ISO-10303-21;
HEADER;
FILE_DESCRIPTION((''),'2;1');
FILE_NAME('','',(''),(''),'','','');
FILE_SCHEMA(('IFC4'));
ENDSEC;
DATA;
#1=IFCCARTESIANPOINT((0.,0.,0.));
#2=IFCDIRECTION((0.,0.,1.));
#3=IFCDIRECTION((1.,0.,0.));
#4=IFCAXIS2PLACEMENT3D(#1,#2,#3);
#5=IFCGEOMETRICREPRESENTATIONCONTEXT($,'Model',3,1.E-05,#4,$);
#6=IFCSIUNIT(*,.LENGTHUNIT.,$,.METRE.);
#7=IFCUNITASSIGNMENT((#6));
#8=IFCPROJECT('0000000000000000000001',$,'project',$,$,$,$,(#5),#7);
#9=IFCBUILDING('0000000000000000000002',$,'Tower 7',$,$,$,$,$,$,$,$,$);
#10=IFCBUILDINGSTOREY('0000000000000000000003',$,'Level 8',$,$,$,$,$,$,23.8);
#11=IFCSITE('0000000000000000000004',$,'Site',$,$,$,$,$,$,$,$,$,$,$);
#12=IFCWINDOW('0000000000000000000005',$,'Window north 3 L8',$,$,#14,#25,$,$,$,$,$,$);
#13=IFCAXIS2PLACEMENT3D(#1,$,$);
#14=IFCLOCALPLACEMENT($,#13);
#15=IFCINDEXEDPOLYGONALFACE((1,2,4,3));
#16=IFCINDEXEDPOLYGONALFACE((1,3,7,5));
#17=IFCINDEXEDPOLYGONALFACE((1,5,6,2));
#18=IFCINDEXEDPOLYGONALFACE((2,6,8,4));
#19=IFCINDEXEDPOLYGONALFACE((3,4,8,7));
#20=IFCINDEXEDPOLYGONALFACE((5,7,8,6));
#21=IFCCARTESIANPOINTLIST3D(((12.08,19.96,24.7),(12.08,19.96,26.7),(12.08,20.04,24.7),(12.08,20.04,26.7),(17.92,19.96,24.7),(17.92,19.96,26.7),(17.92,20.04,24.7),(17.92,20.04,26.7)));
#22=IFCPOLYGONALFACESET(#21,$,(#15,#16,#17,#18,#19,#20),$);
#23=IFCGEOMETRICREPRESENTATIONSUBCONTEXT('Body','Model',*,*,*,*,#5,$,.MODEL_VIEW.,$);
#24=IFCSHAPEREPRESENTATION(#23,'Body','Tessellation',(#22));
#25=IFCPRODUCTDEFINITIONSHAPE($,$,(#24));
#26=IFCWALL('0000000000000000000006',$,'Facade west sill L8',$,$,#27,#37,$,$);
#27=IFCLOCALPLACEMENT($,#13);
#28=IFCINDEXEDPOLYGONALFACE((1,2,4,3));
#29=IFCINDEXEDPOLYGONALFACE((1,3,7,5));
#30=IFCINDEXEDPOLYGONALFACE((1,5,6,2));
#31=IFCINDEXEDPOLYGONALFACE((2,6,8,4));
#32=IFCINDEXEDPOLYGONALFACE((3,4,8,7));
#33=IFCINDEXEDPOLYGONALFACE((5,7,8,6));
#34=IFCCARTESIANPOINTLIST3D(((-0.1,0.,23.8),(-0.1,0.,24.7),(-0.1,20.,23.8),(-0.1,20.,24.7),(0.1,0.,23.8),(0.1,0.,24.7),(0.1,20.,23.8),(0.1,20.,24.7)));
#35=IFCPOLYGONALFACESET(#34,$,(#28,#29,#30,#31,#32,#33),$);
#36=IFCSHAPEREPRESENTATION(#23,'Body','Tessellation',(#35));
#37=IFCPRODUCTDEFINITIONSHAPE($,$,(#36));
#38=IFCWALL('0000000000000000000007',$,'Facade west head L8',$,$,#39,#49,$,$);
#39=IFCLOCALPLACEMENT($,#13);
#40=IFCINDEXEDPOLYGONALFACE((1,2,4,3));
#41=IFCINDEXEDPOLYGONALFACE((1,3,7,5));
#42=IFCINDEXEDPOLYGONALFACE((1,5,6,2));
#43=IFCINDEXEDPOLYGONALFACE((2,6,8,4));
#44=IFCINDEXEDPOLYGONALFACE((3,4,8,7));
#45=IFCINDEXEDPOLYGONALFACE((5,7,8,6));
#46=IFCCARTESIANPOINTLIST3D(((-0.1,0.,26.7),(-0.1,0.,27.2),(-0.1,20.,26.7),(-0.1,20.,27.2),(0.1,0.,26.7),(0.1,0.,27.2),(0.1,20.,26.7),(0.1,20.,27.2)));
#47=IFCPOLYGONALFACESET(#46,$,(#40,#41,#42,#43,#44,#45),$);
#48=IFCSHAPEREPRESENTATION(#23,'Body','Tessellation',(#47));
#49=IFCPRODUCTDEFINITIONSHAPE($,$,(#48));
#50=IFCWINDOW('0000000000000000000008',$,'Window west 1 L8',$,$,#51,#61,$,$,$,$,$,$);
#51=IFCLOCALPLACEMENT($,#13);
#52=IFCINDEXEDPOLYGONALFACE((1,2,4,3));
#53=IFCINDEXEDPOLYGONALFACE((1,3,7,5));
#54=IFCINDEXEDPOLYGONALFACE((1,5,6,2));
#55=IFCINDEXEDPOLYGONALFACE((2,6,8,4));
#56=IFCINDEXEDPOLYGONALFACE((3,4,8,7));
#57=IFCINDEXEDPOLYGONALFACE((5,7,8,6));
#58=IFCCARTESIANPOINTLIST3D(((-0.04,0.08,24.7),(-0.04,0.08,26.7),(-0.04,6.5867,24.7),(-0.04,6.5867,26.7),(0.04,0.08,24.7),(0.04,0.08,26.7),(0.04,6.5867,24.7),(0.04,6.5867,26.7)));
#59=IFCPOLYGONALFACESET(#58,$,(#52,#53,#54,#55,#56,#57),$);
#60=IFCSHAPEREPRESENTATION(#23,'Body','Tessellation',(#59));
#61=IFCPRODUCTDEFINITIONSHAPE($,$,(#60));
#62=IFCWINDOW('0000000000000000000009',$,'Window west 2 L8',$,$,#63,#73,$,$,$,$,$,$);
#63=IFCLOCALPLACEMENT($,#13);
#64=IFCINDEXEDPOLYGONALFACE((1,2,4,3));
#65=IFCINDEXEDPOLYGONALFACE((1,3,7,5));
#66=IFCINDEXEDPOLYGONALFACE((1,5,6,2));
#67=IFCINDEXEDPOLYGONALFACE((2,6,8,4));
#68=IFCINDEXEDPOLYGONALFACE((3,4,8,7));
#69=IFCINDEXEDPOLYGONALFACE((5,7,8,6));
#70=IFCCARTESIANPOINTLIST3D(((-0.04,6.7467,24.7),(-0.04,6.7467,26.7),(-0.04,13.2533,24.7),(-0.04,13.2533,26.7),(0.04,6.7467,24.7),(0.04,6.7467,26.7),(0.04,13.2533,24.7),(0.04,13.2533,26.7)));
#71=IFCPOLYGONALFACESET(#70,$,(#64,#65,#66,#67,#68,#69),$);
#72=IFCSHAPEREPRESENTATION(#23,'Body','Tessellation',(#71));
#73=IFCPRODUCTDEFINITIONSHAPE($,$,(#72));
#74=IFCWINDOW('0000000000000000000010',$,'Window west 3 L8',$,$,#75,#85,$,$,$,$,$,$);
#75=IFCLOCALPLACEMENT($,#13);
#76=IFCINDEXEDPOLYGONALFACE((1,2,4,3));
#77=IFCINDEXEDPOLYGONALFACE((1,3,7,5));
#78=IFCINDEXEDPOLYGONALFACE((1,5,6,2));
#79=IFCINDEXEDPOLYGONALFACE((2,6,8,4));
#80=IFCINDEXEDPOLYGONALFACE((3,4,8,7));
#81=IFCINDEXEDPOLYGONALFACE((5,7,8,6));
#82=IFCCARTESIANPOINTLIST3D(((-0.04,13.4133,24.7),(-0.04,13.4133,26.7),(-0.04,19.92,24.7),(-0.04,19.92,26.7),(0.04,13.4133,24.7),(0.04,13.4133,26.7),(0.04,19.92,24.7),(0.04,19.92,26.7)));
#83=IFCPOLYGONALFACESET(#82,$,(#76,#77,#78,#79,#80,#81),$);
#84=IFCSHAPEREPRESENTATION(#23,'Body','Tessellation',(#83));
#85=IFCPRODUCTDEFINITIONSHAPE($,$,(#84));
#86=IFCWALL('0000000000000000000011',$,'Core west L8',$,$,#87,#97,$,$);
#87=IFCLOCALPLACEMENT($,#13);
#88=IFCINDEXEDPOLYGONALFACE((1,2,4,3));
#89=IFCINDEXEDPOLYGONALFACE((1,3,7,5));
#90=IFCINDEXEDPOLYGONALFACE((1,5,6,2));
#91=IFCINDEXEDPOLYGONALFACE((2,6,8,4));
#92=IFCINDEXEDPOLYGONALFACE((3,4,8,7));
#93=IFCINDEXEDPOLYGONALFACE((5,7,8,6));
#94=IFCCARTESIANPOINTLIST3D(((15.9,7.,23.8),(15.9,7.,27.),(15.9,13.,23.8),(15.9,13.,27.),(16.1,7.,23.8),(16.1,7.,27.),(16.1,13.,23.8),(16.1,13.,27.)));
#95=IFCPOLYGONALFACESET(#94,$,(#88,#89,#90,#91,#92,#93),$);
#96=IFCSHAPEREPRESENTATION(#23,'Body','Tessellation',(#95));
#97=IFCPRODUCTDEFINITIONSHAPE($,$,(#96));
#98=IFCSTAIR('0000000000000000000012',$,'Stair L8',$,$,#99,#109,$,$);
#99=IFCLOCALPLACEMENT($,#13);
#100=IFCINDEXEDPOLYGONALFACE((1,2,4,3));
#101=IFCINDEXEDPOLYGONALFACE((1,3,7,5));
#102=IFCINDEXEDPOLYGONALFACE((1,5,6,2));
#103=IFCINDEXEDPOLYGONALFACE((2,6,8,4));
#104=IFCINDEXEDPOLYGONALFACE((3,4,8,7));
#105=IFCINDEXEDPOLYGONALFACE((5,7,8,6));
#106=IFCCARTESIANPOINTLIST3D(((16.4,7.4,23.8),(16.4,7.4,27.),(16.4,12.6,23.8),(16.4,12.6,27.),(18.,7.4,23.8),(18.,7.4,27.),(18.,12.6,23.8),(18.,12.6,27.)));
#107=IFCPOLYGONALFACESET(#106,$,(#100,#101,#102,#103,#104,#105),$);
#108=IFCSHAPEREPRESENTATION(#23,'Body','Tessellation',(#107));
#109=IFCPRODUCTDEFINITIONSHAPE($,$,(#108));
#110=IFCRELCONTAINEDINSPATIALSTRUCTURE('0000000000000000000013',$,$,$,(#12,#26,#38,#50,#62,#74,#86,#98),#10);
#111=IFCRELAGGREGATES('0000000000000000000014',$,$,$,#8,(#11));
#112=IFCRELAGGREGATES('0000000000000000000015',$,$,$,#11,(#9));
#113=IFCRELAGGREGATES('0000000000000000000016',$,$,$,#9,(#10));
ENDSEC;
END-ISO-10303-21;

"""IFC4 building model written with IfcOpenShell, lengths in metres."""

from ifc_helpers import new_model, si_unit, frame, origin, origin_with_axes, origin_2d, place, context, subcontext, project, spatial, rectangle, extrude, element, save


model = new_model("IFC4")

# Units and contexts
model_context = context("Model", 3, precision=1e-05, world=origin_with_axes())
body_context = subcontext(model_context, "Body", "Model", "MODEL_VIEW")
ifc_project = project(units=[si_unit("LENGTHUNIT", "METRE")], contexts=[model_context])

# Site, building, storey
site = spatial("IfcSite", under=ifc_project, Name="Site")
building = spatial("IfcBuilding", under=site, Name="Tower 7")
storey = spatial("IfcBuildingStorey", under=building, Name="Level 8", Elevation=23.8)

# Window
window_1_placement = place(None, frame((15.0, 20.0, 24.7), z_axis=(0.0, 0.0, 1.0), x_axis=(1.0, 0.0, 0.0)))
element("IfcWindow", 1, at=window_1_placement, inside=storey, Name="Window north 3 L8", context=body_context, shape_type="SweptSolid", body=[
    extrude(rectangle(XDim=5.84, YDim=0.08, at=origin_2d()), origin(), (0.0, 0.0, 1.0), 2.0),
])

# Walls
wall_1_placement = place(None, frame((0.0, 10.0, 23.8), z_axis=(0.0, 0.0, 1.0), x_axis=(1.0, 0.0, 0.0)))
element("IfcWall", 2, at=wall_1_placement, inside=storey, Name="Facade west sill L8", context=body_context, shape_type="SweptSolid", body=[
    extrude(rectangle(XDim=0.2, YDim=20.0, at=origin_2d()), origin(), (0.0, 0.0, 1.0), 0.9),
])
wall_2_placement = place(None, frame((0.0, 10.0, 26.7), z_axis=(0.0, 0.0, 1.0), x_axis=(1.0, 0.0, 0.0)))
element("IfcWall", 3, at=wall_2_placement, inside=storey, Name="Facade west head L8", context=body_context, shape_type="SweptSolid", body=[
    extrude(rectangle(XDim=0.2, YDim=20.0, at=origin_2d()), origin(), (0.0, 0.0, 1.0), 0.5),
])

# Windows
for number, where, z_axis, x_axis, name in (
    (4, (0.0, 3.3333, 24.7), (0.0, 0.0, 1.0), (1.0, 0.0, 0.0), "Window west 1 L8"),
    (5, (0.0, 10.0, 24.7), (0.0, 0.0, 1.0), (1.0, 0.0, 0.0), "Window west 2 L8"),
):
    element("IfcWindow", number, at=place(None, frame(where, z_axis=z_axis, x_axis=x_axis)), inside=storey, Name=name, context=body_context, shape_type="SweptSolid", body=[
        extrude(rectangle(XDim=0.08, YDim=6.5067, at=origin_2d()), origin(), (0.0, 0.0, 1.0), 2.0),
    ])
window_2_placement = place(None, frame((0.0, 16.6667, 24.7), z_axis=(0.0, 0.0, 1.0), x_axis=(1.0, 0.0, 0.0)))
element("IfcWindow", 6, at=window_2_placement, inside=storey, Name="Window west 3 L8", context=body_context, shape_type="SweptSolid", body=[
    extrude(rectangle(XDim=0.08, YDim=6.5067, at=origin_2d()), origin(), (0.0, 0.0, 1.0), 2.0),
])

# Wall
wall_3_placement = place(None, frame((16.0, 10.0, 23.8), z_axis=(0.0, 0.0, 1.0), x_axis=(1.0, 0.0, 0.0)))
element("IfcWall", 7, at=wall_3_placement, inside=storey, Name="Core west L8", context=body_context, shape_type="SweptSolid", body=[
    extrude(rectangle(XDim=0.2, YDim=6.0, at=origin_2d()), origin(), (0.0, 0.0, 1.0), 3.2),
])

# Stair
stair_placement = place(None, frame((17.2, 10.0, 23.8), z_axis=(0.0, 0.0, 1.0), x_axis=(1.0, 0.0, 0.0)))
element("IfcStair", 8, at=stair_placement, inside=storey, Name="Stair L8", context=body_context, shape_type="SweptSolid", body=[
    extrude(rectangle(XDim=1.6, YDim=5.2, at=origin_2d()), origin(), (0.0, 0.0, 1.0), 3.2),
])

save(model, "model.ifc")
